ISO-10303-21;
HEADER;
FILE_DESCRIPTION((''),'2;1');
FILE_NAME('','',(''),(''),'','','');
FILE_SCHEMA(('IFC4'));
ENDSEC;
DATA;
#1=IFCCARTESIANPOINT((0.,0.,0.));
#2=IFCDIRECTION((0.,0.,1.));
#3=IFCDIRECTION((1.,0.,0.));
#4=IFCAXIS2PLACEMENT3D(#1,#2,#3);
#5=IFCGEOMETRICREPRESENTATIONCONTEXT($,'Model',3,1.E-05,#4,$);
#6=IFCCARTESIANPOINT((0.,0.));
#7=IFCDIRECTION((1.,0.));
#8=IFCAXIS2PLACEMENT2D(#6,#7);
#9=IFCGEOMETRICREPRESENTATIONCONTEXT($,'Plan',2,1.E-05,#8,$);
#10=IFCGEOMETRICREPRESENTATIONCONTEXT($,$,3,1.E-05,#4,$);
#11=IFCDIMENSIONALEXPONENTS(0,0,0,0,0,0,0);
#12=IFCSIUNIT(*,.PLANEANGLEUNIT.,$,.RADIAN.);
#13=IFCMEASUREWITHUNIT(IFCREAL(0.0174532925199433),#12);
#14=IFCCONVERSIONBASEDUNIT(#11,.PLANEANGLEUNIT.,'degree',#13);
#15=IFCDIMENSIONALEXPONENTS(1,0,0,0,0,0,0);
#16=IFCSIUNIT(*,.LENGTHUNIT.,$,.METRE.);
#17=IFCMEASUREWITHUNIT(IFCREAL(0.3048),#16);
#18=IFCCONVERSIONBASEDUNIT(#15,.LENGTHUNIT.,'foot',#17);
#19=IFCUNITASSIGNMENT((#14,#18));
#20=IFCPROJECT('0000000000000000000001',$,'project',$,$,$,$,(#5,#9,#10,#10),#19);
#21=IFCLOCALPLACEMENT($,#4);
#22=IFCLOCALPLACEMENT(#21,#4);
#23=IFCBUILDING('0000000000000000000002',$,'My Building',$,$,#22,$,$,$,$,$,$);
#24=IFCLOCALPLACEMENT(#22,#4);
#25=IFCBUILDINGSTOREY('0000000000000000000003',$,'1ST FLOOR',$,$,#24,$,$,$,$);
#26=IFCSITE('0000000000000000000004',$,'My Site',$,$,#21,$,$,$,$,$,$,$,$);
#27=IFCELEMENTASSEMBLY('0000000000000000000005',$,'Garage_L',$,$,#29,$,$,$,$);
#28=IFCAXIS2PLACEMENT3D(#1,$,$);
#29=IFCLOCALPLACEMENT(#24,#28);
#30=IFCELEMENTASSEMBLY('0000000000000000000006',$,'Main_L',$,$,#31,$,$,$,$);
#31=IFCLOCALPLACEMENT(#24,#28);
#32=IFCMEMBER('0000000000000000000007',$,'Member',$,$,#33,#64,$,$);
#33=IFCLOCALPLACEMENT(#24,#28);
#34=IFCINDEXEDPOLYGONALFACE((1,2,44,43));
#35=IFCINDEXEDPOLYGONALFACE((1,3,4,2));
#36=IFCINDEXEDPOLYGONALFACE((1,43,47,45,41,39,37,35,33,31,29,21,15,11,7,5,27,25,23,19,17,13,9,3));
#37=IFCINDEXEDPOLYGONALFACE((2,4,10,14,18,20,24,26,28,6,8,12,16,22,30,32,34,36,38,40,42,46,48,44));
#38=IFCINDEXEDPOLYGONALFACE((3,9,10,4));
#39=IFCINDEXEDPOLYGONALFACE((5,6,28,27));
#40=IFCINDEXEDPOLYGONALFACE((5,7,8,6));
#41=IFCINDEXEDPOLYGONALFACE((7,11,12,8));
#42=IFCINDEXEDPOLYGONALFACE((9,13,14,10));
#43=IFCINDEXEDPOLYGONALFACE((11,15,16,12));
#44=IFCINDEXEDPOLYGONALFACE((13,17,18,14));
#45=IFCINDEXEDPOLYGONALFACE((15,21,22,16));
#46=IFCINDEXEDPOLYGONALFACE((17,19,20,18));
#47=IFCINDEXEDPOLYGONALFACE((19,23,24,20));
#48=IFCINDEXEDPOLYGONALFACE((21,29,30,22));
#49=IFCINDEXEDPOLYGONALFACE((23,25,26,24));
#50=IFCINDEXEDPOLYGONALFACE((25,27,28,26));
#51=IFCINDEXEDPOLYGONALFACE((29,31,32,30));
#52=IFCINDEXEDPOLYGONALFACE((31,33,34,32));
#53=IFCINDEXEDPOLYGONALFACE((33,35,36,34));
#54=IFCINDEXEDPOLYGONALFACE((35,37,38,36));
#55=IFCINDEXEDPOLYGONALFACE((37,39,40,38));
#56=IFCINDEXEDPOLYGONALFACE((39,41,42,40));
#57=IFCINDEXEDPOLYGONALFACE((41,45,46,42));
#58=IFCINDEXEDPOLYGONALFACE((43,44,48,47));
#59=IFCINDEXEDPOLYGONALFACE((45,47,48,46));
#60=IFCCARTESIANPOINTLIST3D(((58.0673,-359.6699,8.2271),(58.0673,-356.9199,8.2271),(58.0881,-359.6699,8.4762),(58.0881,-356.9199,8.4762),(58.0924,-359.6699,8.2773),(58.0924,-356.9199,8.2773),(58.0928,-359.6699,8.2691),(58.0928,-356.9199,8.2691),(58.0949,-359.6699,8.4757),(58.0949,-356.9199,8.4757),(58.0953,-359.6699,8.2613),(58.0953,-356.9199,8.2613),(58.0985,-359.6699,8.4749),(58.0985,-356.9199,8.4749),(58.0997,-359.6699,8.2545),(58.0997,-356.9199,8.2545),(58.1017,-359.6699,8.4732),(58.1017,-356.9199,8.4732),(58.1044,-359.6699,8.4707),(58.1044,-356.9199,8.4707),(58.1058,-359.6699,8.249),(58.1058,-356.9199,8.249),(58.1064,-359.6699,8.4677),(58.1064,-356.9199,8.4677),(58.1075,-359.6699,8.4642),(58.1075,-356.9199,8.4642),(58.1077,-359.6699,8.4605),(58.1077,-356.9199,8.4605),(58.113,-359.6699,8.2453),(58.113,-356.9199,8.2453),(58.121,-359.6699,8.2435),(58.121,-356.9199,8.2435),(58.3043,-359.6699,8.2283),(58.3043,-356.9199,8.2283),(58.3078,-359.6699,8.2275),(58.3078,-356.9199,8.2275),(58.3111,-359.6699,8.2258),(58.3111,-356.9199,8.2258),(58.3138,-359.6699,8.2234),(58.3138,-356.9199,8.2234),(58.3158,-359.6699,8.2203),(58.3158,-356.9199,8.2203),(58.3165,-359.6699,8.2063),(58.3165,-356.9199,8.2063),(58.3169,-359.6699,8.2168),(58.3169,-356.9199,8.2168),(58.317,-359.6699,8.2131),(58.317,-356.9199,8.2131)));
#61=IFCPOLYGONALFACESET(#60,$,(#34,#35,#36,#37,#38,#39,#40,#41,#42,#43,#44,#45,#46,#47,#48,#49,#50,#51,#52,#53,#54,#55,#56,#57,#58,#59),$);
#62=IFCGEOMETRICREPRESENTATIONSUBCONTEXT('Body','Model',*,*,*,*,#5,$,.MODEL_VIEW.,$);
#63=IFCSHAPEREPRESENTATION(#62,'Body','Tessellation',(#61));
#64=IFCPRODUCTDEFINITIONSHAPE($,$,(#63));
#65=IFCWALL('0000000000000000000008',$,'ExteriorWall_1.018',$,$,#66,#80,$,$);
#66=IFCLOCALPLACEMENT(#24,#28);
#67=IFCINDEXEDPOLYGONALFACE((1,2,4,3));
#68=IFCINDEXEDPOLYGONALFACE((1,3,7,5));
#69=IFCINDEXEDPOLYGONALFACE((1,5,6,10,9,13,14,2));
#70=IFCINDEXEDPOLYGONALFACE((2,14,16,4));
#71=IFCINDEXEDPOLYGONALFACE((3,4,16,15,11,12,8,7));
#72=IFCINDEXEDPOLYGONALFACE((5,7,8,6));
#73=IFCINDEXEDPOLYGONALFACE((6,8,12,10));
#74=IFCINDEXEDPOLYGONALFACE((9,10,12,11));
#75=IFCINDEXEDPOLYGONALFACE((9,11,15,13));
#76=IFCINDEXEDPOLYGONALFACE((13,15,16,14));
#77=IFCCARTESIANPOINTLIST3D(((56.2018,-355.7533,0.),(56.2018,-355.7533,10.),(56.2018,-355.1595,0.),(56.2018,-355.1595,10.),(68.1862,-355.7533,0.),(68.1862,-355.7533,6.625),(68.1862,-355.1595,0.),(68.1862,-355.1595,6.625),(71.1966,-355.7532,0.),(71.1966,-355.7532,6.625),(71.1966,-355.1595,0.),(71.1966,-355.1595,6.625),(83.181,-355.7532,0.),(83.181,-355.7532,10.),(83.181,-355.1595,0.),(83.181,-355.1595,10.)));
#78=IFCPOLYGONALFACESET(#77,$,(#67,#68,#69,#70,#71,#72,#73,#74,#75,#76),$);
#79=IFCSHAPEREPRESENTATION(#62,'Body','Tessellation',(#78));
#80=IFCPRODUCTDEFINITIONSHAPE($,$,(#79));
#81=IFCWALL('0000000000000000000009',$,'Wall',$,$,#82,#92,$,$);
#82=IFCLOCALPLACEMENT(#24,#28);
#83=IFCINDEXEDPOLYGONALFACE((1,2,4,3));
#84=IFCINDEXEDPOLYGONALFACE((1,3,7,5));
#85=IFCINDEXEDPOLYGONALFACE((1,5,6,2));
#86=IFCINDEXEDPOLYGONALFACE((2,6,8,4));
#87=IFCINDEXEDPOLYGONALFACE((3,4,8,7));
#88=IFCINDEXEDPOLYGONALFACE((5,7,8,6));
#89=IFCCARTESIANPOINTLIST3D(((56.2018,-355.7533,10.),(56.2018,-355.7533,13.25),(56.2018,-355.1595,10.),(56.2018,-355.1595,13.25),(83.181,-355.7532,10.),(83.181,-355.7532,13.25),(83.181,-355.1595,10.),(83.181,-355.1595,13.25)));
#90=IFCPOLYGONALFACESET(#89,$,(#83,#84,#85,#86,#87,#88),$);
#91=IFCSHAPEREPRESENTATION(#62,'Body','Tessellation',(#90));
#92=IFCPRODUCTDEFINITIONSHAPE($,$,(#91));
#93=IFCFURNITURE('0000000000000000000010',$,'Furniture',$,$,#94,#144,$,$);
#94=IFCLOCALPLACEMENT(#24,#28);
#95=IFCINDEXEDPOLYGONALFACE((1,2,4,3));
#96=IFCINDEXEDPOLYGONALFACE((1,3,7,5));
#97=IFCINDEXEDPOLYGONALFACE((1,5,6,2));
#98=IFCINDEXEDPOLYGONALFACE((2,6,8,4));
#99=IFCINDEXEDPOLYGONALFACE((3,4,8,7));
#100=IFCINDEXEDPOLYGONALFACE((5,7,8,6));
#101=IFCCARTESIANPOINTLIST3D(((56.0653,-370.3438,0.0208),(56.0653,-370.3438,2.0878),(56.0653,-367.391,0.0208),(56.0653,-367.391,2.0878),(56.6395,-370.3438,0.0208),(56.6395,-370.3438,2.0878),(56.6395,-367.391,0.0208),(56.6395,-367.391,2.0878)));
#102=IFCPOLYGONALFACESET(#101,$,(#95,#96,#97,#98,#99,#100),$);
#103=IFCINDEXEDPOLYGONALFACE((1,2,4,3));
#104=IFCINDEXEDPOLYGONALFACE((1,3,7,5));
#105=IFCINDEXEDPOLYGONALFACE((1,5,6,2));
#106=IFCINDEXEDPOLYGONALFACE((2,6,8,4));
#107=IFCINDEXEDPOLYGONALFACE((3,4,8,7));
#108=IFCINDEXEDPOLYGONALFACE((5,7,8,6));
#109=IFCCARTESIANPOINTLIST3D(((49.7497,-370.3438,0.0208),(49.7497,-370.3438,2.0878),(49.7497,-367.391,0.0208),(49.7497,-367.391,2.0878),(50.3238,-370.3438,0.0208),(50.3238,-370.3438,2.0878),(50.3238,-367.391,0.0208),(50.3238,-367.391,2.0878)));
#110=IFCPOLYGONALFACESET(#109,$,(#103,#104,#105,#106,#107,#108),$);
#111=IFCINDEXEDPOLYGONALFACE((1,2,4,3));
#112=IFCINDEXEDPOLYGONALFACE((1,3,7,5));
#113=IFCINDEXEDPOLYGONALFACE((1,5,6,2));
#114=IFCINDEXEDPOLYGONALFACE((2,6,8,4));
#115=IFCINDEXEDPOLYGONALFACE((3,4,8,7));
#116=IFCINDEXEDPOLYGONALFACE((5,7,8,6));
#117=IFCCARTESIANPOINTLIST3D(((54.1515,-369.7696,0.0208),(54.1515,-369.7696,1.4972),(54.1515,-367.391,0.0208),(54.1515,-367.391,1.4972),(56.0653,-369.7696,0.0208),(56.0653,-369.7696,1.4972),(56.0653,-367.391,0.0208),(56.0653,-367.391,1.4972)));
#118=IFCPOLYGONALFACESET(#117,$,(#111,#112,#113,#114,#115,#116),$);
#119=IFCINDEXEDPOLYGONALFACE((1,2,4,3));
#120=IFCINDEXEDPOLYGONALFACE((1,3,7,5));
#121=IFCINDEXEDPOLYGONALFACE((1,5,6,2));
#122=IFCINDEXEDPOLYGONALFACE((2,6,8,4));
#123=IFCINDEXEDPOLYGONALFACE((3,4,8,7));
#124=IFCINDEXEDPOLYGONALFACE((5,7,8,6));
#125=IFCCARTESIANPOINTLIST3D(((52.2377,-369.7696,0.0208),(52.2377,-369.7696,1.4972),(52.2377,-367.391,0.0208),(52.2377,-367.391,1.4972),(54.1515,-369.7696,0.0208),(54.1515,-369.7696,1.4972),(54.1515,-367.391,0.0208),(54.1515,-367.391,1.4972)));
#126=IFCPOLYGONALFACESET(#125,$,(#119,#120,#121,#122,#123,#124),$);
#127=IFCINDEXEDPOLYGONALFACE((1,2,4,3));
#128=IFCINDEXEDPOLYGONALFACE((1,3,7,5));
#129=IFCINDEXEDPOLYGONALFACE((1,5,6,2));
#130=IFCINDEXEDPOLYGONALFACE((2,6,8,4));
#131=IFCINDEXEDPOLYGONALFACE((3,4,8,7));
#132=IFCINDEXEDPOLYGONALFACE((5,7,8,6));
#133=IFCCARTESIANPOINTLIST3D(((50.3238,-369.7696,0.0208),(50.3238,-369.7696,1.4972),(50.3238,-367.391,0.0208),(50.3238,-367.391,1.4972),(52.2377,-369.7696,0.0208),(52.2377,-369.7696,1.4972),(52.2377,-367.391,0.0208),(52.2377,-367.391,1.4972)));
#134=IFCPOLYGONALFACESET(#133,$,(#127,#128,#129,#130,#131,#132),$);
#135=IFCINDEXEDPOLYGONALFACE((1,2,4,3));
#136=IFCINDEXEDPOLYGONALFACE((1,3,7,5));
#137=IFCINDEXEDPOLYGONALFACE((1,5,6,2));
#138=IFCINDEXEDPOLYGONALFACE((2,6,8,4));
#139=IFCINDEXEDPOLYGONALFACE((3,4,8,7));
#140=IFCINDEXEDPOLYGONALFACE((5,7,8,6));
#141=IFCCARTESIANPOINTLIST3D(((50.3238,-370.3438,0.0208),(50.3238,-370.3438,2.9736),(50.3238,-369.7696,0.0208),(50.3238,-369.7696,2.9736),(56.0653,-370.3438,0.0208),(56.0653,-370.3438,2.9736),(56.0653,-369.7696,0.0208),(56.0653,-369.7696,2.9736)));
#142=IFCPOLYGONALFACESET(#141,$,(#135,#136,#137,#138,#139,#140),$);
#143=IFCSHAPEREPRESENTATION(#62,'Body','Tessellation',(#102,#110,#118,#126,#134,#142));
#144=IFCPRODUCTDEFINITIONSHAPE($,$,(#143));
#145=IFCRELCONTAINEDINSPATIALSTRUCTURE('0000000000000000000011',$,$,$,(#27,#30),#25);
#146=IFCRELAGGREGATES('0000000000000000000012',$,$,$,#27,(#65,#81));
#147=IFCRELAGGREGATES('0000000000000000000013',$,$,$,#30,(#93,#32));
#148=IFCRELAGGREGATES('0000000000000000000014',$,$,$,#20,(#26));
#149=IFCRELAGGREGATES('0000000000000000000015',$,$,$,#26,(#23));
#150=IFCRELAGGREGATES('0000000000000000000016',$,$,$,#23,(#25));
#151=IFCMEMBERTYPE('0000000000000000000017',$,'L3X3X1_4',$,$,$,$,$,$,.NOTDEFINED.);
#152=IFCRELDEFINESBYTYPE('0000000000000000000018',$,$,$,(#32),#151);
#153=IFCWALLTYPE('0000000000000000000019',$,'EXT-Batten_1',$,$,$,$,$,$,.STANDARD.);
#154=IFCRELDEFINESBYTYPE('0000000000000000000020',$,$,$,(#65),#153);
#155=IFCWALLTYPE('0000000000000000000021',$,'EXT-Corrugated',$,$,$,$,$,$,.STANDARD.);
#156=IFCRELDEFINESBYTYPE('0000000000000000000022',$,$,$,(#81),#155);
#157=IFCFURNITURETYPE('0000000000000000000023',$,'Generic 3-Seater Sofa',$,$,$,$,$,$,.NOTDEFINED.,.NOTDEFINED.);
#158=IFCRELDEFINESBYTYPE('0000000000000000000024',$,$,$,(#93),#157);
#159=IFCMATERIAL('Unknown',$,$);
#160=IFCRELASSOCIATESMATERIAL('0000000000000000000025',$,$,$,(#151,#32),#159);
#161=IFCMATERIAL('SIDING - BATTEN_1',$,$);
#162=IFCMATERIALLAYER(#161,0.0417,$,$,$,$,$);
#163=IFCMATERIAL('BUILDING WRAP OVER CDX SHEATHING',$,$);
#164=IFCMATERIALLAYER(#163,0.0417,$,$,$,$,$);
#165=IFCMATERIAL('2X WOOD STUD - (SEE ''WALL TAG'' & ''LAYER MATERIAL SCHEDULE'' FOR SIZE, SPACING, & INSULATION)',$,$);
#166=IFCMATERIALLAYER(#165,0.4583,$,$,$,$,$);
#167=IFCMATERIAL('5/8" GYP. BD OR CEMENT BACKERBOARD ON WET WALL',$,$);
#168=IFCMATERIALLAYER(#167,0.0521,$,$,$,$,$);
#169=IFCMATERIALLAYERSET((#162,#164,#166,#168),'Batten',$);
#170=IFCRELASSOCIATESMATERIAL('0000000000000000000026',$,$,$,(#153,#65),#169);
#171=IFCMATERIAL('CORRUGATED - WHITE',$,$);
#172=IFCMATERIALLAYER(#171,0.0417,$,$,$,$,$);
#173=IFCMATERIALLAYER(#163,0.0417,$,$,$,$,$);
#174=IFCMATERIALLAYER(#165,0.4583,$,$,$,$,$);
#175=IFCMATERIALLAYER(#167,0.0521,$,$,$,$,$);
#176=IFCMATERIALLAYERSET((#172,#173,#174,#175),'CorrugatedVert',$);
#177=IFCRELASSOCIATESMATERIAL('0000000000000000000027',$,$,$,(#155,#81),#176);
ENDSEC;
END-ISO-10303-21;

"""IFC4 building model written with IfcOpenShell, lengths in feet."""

from ifc_helpers import new_model, entity, si_unit, converted_unit, frame, origin_with_axes, origin_2d_with_axis, place, context, subcontext, project, spatial, line, indexed_curve, l_section, outline, extrude, source, transform, mapped, material, layer, layer_set, layer_usage, material_profile, profile_set, profile_usage, type_object, type_shapes, element, aggregate, save


model = new_model("IFC4")

# Units and contexts
model_context = context("Model", 3, precision=1e-05, world=origin_with_axes())
plan_context = context("Plan", 2, precision=1e-05, world=origin_2d_with_axis())
context_of_model = context(None, 3, precision=1e-05, world=origin_with_axes())
body_context = subcontext(model_context, "Body", "Model", "MODEL_VIEW")
ifc_project = project(units=[converted_unit("PLANEANGLEUNIT", "degree", entity("IfcReal", 0.0174532925199433), si_unit("PLANEANGLEUNIT", "RADIAN"), dimensions=[0, 0, 0, 0, 0, 0, 0]), converted_unit("LENGTHUNIT", "foot", entity("IfcReal", 0.3048), si_unit("LENGTHUNIT", "METRE"), dimensions=[1, 0, 0, 0, 0, 0, 0])], contexts=[model_context, plan_context, context_of_model, context_of_model])

# Site, building, storey
site_placement = place(None, origin_with_axes())
site = spatial("IfcSite", under=ifc_project, at=site_placement, Name="My Site")
building_placement = place(site_placement, origin_with_axes())
building = spatial("IfcBuilding", under=site, at=building_placement, Name="My Building")
storey_placement = place(building_placement, origin_with_axes())
storey = spatial("IfcBuildingStorey", under=building, at=storey_placement, Name="1ST FLOOR")

# Element assemblies
assembly_1_placement = place(storey_placement, origin_with_axes())
assembly_1 = element("IfcElementAssembly", 1, at=assembly_1_placement, inside=storey, Name="Garage_L")
assembly_2_placement = place(storey_placement, origin_with_axes())
assembly_2 = element("IfcElementAssembly", 2, at=assembly_2_placement, inside=storey, Name="Main_L")

# Member
ifc_material_1 = material(Name="Unknown")
ifc_material_profile_1 = material_profile(ifc_material_1, l_section(Depth=0.25, Width=0.25, Thickness=0.0208, FilletRadius=0.0312, EdgeRadius=0.014))
ifc_profile_set_1 = profile_set([ifc_material_profile_1])
ifc_profile_usage_1 = profile_usage(ifc_profile_set_1, cardinal=5)
member_type_1 = type_object("IfcMemberType", Name="L3X3X1_4", PredefinedType="NOTDEFINED", material=ifc_profile_set_1)
member_1_placement = place(assembly_2_placement, frame((58.2023, -356.9199, 8.3413), z_axis=(0.0, -1.0, 0.0), x_axis=(0.996551, 0.0, -0.082982)))
member_1 = element("IfcMember", 3, at=member_1_placement, type_object=member_type_1, material=ifc_profile_usage_1, Name="Member", context=body_context, shape_type="SweptSolid", body=[
    extrude(l_section(Depth=0.25, Width=0.25, Thickness=0.0208, FilletRadius=0.0312, EdgeRadius=0.014), origin_with_axes(), (0.0, 0.0, 1.0), 2.75),
])

# Wall, opening
ifc_material_2 = material(Name="SIDING - BATTEN_1")
ifc_layer_1 = layer(ifc_material_2, 0.0417)
ifc_material_3 = material(Name="BUILDING WRAP OVER CDX SHEATHING")
ifc_layer_2 = layer(ifc_material_3, 0.0417)
ifc_material_4 = material(Name="2X WOOD STUD - (SEE 'WALL TAG' & 'LAYER MATERIAL SCHEDULE' FOR SIZE, SPACING, & INSULATION)")
ifc_layer_3 = layer(ifc_material_4, 0.4583)
ifc_material_5 = material(Name="5/8\" GYP. BD OR CEMENT BACKERBOARD ON WET WALL")
ifc_layer_4 = layer(ifc_material_5, 0.0521)
ifc_layer_set_1 = layer_set([ifc_layer_1, ifc_layer_2, ifc_layer_3, ifc_layer_4], Name="Batten")
ifc_layer_usage_1 = layer_usage(ifc_layer_set_1, "AXIS2", "POSITIVE", 0.0)
wall_type_1 = type_object("IfcWallType", Name="EXT-Batten_1", PredefinedType="STANDARD", material=ifc_layer_set_1)
wall_1_placement = place(assembly_1_placement, frame((56.2018, -355.7533, 0.0), z_axis=(0.0, 0.0, 1.0), x_axis=(1.0, 0.000001, 0.0)))
wall_1 = element("IfcWall", 4, at=wall_1_placement, type_object=wall_type_1, material=ifc_layer_usage_1, Name="ExteriorWall_1.018", context=body_context, shape_type="SweptSolid", body=[
    extrude(outline(indexed_curve([(0.0, 0.0), (0.0, 0.5938), (26.9792, 0.5938), (26.9792, 0.0), (0.0, 0.0)], self_intersect=False)), origin_with_axes(), (0.0, 0.0, 1.0), 10.0),
])
shared_shape_1 = source(origin_with_axes(), body_context, "Body", "SweptSolid", [
    extrude(outline(indexed_curve([(0.0, 0.0), (3.0104, 0.0), (3.0104, 6.625), (0.0, 6.625)], segments=[line(1, 2, 3, 4, 1)])), frame((0.0, -1.9685, 0.0), z_axis=(0.0, -1.0, 0.0), x_axis=(1.0, 0.0, 0.0)), (0.0, 0.0, -1.0), 3.937),
])
opening_1_placement = place(wall_1_placement, frame((11.9844, 0.0, 0.0), z_axis=(0.0, 0.0, 1.0), x_axis=(1.0, 0.0, 0.0)))
element("IfcOpeningElement", 5, at=opening_1_placement, cuts=wall_1, PredefinedType="OPENING", context=body_context, shape_type="MappedRepresentation", body=[
    mapped(shared_shape_1, transform((0.0, 0.0, 0.0), x_axis=(1.0, 0.0, 0.0), y_axis=(0.0, 1.0, 0.0), z_axis=(0.0, 0.0, 1.0), scale=1.0)),
])

# Wall
ifc_material_6 = material(Name="CORRUGATED - WHITE")
ifc_layer_5 = layer(ifc_material_6, 0.0417)
ifc_layer_6 = layer(ifc_material_3, 0.0417)
ifc_layer_7 = layer(ifc_material_4, 0.4583)
ifc_layer_8 = layer(ifc_material_5, 0.0521)
ifc_layer_set_2 = layer_set([ifc_layer_5, ifc_layer_6, ifc_layer_7, ifc_layer_8], Name="CorrugatedVert")
ifc_layer_usage_2 = layer_usage(ifc_layer_set_2, "AXIS2", "POSITIVE", 0.0)
wall_type_2 = type_object("IfcWallType", Name="EXT-Corrugated", PredefinedType="STANDARD", material=ifc_layer_set_2)
wall_2_placement = place(assembly_1_placement, frame((56.2018, -355.7533, 10.0), z_axis=(0.0, 0.0, 1.0), x_axis=(1.0, 0.000001, 0.0)))
wall_2 = element("IfcWall", 6, at=wall_2_placement, type_object=wall_type_2, material=ifc_layer_usage_2, Name="Wall", context=body_context, shape_type="SweptSolid", body=[
    extrude(outline(indexed_curve([(0.0, 0.0), (0.0, 0.5938), (26.9792, 0.5938), (26.9792, 0.0), (0.0, 0.0)], self_intersect=False)), origin_with_axes(), (0.0, 0.0, 1.0), 3.25),
])
aggregate(assembly_1, [wall_1, wall_2])

# Furniture
furniture_type = type_object("IfcFurnitureType", Name="Generic 3-Seater Sofa", AssemblyPlace="NOTDEFINED", PredefinedType="NOTDEFINED")
shared_shape_2 = source(origin_with_axes(), body_context, "Body", "SweptSolid", [
    extrude(outline(indexed_curve([(0.0, 0.0), (0.5741, 0.0), (0.5741, 2.9528), (0.0, 2.9528)], segments=[line(1, 2), line(2, 3), line(3, 4), line(4, 1)])), frame((-3.4449, -2.9528, 0.0), z_axis=(0.0, 0.0, 1.0), x_axis=(1.0, 0.0, 0.0)), (0.0, 0.0, 1.0), 2.0669),
    extrude(outline(indexed_curve([(0.0, 0.0), (0.5741, 0.0), (0.5741, 2.9528), (0.0, 2.9528)], segments=[line(1, 2), line(2, 3), line(3, 4), line(4, 1)])), frame((2.8707, -2.9528, 0.0), z_axis=(0.0, 0.0, 1.0), x_axis=(1.0, 0.0, 0.0)), (0.0, 0.0, 1.0), 2.0669),
    extrude(outline(indexed_curve([(0.5741, 0.0), (2.488, 0.0), (2.488, 2.3786), (0.5741, 2.3786)], segments=[line(1, 2), line(2, 3), line(3, 4), line(4, 1)])), frame((-3.4449, -2.9528, 0.0), z_axis=(0.0, 0.0, 1.0), x_axis=(1.0, 0.0, 0.0)), (0.0, 0.0, 1.0), 1.4764),
    extrude(outline(indexed_curve([(2.488, 0.0), (4.4018, 0.0), (4.4018, 2.3786), (2.488, 2.3786)], segments=[line(1, 2), line(2, 3), line(3, 4), line(4, 1)])), frame((-3.4449, -2.9528, 0.0), z_axis=(0.0, 0.0, 1.0), x_axis=(1.0, 0.0, 0.0)), (0.0, 0.0, 1.0), 1.4764),
    extrude(outline(indexed_curve([(4.4018, 0.0), (6.3156, 0.0), (6.3156, 2.3786), (4.4018, 2.3786)], segments=[line(1, 2), line(2, 3), line(3, 4), line(4, 1)])), frame((-3.4449, -2.9528, 0.0), z_axis=(0.0, 0.0, 1.0), x_axis=(1.0, 0.0, 0.0)), (0.0, 0.0, 1.0), 1.4764),
    extrude(outline(indexed_curve([(0.5741, 2.3786), (6.3156, 2.3786), (6.3156, 2.9528), (0.5741, 2.9528)], segments=[line(1, 2), line(2, 3), line(3, 4), line(4, 1)])), frame((-3.4449, -2.9528, 0.0), z_axis=(0.0, 0.0, 1.0), x_axis=(1.0, 0.0, 0.0)), (0.0, 0.0, 1.0), 2.9528),
])
type_shapes(furniture_type, [shared_shape_2])
furniture_placement = place(assembly_2_placement, frame((53.1946, -370.3438, 0.0208), z_axis=(0.0, 0.0, 1.0), x_axis=(-1.0, 0.0, 0.0)))
furniture = element("IfcFurniture", 7, at=furniture_placement, type_object=furniture_type, Name="Furniture", context=body_context, shape_type="MappedRepresentation", body=[
    mapped(shared_shape_2, transform((0.0, 0.0, 0.0), x_axis=(1.0, 0.0, 0.0), y_axis=(0.0, 1.0, 0.0), z_axis=(0.0, 0.0, 1.0), scale=1.0)),
])
aggregate(assembly_2, [furniture, member_1])

save(model, "model.ifc")
